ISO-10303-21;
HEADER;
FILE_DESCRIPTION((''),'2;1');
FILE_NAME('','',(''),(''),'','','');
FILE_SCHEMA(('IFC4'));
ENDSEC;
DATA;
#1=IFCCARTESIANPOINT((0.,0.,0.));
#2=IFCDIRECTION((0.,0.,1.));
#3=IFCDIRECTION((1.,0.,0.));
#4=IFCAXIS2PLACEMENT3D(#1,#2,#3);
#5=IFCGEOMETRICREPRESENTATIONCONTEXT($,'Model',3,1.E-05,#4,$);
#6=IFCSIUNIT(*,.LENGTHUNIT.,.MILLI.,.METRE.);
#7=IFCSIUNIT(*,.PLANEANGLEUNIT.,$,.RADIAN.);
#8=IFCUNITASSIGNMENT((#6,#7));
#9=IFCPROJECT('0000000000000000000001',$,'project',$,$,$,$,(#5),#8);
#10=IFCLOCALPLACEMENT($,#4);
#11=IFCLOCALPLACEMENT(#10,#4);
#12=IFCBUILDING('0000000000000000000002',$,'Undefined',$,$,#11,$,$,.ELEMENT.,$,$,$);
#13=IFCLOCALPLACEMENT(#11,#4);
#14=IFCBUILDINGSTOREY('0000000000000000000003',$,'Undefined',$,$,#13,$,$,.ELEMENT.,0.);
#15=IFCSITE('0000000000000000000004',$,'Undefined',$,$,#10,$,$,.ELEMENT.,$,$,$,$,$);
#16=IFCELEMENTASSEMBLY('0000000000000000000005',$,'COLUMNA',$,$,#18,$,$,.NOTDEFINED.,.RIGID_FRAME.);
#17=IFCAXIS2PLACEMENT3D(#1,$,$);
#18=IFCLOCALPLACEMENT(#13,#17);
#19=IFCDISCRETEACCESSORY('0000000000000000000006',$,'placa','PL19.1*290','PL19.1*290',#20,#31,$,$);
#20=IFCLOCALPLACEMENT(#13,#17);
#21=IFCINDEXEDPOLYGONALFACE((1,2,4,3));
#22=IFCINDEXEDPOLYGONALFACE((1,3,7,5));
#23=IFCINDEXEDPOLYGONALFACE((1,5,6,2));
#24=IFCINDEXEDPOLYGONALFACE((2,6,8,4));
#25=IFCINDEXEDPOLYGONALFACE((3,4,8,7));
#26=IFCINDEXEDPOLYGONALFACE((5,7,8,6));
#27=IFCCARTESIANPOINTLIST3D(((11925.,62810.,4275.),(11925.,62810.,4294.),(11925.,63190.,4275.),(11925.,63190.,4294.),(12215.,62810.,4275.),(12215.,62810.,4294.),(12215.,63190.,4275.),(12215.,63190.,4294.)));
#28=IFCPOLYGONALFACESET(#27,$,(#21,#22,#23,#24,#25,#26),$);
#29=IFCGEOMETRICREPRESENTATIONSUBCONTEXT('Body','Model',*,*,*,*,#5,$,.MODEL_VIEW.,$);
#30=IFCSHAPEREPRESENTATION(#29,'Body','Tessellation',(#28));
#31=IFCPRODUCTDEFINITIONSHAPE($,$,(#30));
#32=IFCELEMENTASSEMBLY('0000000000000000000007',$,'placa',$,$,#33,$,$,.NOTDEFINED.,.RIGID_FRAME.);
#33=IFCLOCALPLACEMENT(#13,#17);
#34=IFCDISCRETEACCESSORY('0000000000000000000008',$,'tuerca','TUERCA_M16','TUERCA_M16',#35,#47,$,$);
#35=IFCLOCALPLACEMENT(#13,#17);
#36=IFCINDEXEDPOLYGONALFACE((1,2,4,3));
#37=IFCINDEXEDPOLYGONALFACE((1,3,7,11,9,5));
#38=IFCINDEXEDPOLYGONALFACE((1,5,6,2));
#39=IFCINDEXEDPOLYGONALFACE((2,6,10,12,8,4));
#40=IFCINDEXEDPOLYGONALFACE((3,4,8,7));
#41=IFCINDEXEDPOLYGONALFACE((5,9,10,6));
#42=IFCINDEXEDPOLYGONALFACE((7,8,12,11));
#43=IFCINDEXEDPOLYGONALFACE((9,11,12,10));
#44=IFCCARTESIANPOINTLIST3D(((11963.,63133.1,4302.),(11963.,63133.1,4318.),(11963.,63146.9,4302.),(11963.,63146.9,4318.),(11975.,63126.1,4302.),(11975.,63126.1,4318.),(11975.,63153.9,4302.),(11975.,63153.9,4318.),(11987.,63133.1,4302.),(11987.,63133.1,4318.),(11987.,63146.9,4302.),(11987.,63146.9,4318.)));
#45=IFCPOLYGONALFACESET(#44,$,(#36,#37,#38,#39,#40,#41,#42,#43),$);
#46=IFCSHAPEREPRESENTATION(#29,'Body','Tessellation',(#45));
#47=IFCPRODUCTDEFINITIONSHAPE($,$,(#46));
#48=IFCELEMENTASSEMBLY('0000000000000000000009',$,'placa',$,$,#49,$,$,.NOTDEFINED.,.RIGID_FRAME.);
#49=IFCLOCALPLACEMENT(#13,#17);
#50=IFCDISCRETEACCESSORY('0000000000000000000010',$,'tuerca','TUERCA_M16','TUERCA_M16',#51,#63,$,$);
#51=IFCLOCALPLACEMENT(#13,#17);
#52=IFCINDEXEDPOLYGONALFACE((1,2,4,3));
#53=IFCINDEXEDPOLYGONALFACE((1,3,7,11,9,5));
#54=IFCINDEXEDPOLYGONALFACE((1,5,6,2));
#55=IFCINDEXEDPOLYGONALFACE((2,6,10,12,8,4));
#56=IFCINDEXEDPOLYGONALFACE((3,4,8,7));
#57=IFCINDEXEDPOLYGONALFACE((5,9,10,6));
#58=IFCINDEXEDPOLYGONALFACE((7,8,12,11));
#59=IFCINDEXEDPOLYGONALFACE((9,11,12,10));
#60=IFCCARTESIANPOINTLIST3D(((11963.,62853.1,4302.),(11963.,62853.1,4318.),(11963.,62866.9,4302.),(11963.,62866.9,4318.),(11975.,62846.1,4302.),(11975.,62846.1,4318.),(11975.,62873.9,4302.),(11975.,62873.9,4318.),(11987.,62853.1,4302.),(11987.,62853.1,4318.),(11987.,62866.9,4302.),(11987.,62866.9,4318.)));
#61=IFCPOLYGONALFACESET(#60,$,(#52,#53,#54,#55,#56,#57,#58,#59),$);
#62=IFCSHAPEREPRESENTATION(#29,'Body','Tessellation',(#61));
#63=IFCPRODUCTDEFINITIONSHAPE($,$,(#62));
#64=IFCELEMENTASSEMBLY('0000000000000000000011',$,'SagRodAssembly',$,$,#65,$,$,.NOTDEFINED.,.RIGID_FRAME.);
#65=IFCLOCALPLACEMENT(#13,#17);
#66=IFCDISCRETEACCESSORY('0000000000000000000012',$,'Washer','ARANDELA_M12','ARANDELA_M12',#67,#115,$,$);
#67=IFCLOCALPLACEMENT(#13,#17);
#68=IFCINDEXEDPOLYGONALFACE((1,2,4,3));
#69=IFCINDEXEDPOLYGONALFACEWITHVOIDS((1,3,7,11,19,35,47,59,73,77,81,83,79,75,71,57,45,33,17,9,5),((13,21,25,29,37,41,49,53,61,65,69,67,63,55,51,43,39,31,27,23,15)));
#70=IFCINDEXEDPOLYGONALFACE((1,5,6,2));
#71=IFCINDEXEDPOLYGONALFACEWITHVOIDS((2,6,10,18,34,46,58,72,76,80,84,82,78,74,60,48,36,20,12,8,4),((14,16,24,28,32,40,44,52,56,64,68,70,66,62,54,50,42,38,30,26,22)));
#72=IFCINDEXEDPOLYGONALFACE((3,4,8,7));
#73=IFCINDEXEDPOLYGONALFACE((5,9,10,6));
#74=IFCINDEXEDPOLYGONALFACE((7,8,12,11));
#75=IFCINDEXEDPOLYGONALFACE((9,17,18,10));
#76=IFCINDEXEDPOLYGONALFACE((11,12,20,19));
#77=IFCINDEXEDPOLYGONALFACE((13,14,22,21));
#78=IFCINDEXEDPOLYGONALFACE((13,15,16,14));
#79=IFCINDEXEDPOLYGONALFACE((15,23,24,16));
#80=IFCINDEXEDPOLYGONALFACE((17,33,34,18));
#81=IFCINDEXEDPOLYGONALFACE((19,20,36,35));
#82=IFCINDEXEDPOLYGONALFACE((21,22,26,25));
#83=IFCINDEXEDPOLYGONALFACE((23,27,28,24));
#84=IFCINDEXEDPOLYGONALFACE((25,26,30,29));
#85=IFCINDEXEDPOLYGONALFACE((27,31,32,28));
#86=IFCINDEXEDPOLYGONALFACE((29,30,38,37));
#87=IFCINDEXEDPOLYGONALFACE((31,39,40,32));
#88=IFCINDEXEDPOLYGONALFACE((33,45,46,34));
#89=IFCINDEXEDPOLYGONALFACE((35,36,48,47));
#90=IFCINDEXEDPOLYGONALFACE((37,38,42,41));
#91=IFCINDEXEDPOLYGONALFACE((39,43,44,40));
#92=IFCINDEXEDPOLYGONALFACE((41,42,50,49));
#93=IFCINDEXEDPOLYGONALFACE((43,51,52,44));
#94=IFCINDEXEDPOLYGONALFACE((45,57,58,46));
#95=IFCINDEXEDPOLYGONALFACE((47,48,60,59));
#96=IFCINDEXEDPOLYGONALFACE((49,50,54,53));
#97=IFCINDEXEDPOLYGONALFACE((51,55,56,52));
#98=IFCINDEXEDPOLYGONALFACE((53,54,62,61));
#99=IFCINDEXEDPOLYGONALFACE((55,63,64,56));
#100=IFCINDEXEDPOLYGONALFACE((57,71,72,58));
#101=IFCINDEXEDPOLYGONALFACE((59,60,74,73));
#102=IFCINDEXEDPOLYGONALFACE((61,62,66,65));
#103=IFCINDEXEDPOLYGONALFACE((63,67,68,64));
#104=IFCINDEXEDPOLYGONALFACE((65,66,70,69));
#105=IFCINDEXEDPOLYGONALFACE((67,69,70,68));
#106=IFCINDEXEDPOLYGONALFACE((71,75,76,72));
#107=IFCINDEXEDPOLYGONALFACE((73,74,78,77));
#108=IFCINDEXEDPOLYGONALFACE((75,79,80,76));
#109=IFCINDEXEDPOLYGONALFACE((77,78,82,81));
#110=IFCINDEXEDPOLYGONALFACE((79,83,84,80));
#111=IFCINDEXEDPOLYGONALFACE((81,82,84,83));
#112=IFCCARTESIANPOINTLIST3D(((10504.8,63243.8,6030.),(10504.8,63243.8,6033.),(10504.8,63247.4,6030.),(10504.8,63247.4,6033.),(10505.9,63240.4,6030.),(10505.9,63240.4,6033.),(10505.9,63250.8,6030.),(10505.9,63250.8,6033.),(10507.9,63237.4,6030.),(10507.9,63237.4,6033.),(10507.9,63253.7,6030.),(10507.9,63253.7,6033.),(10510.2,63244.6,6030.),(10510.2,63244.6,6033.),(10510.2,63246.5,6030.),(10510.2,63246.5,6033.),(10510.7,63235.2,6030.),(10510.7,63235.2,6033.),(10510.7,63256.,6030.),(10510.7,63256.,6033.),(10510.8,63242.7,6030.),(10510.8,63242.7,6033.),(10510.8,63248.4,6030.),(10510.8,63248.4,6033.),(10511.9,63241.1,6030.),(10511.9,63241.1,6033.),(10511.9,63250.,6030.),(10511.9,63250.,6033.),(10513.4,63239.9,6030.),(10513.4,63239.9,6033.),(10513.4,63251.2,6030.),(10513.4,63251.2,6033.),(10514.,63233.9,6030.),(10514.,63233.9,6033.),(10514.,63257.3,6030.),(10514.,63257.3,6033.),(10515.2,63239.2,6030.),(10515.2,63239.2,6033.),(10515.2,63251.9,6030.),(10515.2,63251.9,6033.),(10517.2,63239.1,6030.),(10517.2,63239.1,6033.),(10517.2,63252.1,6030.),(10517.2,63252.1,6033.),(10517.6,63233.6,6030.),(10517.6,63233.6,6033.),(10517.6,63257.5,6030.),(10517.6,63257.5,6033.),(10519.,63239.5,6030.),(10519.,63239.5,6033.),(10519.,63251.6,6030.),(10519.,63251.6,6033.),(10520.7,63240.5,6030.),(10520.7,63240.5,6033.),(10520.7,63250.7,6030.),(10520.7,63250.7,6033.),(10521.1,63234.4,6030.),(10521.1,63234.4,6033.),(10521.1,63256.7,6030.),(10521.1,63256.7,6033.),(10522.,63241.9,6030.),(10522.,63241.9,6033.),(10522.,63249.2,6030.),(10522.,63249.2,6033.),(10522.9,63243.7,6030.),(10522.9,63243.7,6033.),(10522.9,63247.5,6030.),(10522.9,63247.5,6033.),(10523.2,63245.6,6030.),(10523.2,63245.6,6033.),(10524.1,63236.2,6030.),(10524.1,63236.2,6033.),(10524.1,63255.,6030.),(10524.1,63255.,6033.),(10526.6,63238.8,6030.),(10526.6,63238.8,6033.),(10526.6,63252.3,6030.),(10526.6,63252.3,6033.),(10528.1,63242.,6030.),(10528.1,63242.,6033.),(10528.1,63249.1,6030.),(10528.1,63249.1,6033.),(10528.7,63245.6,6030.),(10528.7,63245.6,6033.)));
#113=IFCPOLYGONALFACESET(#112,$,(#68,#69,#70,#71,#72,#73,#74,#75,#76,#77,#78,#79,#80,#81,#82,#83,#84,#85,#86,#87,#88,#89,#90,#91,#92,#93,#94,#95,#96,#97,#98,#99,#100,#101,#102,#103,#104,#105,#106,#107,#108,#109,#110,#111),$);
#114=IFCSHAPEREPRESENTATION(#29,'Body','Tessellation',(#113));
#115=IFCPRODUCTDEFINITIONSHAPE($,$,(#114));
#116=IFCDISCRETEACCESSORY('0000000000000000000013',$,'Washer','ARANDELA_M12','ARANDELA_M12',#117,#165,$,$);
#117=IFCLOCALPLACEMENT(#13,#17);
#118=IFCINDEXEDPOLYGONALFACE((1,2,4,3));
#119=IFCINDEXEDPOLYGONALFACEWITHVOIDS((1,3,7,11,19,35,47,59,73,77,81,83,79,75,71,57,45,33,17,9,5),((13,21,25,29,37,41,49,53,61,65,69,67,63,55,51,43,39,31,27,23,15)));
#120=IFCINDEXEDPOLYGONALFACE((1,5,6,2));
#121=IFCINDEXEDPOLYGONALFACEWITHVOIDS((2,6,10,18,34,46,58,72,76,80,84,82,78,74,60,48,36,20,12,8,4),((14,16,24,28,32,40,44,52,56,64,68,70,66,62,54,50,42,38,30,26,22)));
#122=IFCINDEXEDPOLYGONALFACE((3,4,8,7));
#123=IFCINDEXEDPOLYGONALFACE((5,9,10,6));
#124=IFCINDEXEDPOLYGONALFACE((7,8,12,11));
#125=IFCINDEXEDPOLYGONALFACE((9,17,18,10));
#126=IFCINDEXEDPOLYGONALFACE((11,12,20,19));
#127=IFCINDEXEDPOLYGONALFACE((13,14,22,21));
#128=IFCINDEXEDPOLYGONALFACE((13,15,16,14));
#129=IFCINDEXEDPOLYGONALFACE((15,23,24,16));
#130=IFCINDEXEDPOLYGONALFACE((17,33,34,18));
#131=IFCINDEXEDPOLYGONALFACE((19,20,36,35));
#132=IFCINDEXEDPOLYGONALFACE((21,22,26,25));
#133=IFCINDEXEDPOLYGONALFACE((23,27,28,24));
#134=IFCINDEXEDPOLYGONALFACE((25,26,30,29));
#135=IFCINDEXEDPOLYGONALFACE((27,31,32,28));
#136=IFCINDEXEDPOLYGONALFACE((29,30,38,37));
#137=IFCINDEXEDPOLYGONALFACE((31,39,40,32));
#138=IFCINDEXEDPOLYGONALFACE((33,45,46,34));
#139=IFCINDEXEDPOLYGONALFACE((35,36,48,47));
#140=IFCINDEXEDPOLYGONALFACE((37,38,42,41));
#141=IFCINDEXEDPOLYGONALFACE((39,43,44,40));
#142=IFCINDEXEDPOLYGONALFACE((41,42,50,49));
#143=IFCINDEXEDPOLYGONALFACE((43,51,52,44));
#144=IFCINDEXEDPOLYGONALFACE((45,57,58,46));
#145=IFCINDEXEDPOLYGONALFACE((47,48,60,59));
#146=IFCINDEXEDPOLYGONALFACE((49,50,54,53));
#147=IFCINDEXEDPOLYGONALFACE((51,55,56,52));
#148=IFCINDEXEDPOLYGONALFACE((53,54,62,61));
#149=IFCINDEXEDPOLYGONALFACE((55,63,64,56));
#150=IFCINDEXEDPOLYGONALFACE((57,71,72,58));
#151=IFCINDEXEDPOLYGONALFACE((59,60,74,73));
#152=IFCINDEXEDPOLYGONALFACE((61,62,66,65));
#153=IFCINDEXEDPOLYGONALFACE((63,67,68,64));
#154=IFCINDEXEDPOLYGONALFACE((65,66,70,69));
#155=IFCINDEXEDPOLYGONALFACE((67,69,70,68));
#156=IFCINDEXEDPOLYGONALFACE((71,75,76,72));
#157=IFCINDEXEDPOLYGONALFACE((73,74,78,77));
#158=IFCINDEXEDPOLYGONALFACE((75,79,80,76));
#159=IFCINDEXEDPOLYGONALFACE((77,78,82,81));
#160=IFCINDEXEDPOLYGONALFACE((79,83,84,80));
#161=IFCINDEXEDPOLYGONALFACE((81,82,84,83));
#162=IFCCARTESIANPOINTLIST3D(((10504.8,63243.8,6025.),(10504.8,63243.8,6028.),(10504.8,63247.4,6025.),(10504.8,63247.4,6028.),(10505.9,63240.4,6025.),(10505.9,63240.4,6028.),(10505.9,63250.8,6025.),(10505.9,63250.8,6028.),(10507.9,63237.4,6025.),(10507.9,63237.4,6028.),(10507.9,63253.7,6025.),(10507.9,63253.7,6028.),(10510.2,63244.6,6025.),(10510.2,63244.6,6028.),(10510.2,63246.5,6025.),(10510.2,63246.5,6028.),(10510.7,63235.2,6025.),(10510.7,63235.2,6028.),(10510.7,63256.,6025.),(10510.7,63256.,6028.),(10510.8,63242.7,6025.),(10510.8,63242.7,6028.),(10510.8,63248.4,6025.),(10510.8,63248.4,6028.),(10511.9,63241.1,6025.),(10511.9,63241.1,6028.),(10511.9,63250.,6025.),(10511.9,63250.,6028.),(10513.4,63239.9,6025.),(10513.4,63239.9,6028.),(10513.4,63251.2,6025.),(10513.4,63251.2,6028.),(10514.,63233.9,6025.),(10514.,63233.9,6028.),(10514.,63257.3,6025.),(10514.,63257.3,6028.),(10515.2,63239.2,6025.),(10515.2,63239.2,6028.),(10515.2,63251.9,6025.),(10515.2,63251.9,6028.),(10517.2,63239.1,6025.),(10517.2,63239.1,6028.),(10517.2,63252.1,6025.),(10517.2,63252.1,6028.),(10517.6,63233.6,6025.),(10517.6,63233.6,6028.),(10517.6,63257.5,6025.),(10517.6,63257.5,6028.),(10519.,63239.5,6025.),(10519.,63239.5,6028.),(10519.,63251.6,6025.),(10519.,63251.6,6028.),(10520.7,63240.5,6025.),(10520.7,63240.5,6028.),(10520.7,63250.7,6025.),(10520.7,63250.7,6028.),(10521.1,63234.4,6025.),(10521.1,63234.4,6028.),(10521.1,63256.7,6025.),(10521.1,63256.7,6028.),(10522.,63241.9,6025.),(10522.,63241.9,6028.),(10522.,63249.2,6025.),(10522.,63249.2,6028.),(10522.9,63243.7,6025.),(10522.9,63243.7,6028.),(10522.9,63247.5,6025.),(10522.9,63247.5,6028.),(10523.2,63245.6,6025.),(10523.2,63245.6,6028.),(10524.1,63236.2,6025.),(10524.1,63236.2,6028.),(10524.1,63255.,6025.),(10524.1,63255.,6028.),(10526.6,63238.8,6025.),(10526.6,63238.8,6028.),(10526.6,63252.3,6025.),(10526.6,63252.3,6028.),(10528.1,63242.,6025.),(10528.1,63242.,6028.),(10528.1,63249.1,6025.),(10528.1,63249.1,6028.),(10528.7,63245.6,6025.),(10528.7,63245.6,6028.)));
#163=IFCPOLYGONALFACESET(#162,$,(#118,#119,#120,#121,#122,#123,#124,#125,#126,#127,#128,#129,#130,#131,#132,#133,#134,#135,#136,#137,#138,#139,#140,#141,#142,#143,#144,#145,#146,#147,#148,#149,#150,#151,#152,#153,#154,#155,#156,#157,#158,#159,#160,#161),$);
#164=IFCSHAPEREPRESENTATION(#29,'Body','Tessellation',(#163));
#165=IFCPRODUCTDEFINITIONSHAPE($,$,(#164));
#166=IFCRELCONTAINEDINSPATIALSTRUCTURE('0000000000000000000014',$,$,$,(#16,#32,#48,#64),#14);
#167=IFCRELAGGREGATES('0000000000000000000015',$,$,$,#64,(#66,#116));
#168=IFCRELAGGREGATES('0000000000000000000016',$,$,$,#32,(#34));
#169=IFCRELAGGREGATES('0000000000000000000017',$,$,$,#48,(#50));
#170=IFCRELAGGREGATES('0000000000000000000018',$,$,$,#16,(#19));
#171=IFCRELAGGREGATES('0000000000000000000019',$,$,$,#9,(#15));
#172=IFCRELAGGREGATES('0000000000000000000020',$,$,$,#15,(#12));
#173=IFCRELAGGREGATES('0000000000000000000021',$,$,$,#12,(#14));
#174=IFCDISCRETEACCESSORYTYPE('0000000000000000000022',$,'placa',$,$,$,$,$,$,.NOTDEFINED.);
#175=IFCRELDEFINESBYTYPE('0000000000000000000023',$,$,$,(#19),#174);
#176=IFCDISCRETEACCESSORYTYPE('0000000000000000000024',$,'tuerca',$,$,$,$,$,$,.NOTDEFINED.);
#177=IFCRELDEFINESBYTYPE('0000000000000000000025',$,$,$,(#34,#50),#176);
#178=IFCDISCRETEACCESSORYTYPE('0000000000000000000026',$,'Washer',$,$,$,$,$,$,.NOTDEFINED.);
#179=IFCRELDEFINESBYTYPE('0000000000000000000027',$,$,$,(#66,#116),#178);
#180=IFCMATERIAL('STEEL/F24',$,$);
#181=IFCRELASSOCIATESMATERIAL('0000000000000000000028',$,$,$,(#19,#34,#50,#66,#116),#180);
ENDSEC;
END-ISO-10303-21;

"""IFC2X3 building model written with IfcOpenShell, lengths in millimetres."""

from ifc_helpers import new_model, si_unit, frame, origin_with_axes, origin_2d_with_axis, place, context, subcontext, project, spatial, polyline, hollow_circle, outline, extrude, material, type_object, element, aggregate, save


model = new_model("IFC2X3")

# Units and contexts
model_context = context("Model", 3, precision=1e-05, world=origin_with_axes())
body_context = subcontext(model_context, "Body", "Model", "MODEL_VIEW")
ifc_project = project(units=[si_unit("LENGTHUNIT", "METRE", prefix="MILLI"), si_unit("PLANEANGLEUNIT", "RADIAN")], contexts=[model_context])

# Site, building, storey
site_placement = place(None, origin_with_axes())
site = spatial("IfcSite", under=ifc_project, at=site_placement, Name="Undefined", CompositionType="ELEMENT")
building_placement = place(site_placement, origin_with_axes())
building = spatial("IfcBuilding", under=site, at=building_placement, Name="Undefined", CompositionType="ELEMENT")
storey_placement = place(building_placement, origin_with_axes())
storey = spatial("IfcBuildingStorey", under=building, at=storey_placement, Name="Undefined", CompositionType="ELEMENT", Elevation=0.0)

# Element assembly
assembly_1_placement = place(storey_placement, origin_with_axes())
assembly_1 = element("IfcElementAssembly", 1, at=assembly_1_placement, inside=storey, Name="COLUMNA", AssemblyPlace="NOTDEFINED", PredefinedType="RIGID_FRAME")
ifc_material_1 = material(Name="STEEL/F24")

# Discrete accessory
discrete_accessory_type_1 = type_object("IfcDiscreteAccessoryType", Name="placa")
discrete_accessory_1_placement = place(assembly_1_placement, frame((12070.0, 63190.0, 4284.5), z_axis=(0.0, 0.0, 1.0), x_axis=(0.0, -1.0, 0.0)))
discrete_accessory_1 = element("IfcDiscreteAccessory", 2, at=discrete_accessory_1_placement, type_object=discrete_accessory_type_1, material=ifc_material_1, Name="placa", Description="PL19.1*290", ObjectType="PL19.1*290", context=body_context, shape_type="SweptSolid", body=[
    extrude(outline(polyline([(380.0, -145.0), (0.0, -145.0), (0.0, 145.0), (380.0, 145.0), (380.0, -145.0)])), frame((0.0, 0.0, -9.6), z_axis=(0.0, 0.0, 1.0), x_axis=(1.0, 0.0, 0.0)), (0.0, 0.0, 1.0), 19.1),
])

# Element assemblies, discrete accessories
assembly_2_placement = place(storey_placement, origin_with_axes())
assembly_2 = element("IfcElementAssembly", 3, at=assembly_2_placement, inside=storey, Name="placa", AssemblyPlace="NOTDEFINED", PredefinedType="RIGID_FRAME")
discrete_accessory_type_2 = type_object("IfcDiscreteAccessoryType", Name="tuerca")
discrete_accessory_2_placement = place(assembly_2_placement, frame((11975.0, 63140.0, 4318.1), z_axis=(0.0, 0.0, -1.0), x_axis=(0.0, -1.0, 0.0)))
discrete_accessory_2 = element("IfcDiscreteAccessory", 4, at=discrete_accessory_2_placement, type_object=discrete_accessory_type_2, material=ifc_material_1, Name="tuerca", Description="TUERCA_M16", ObjectType="TUERCA_M16", context=body_context, shape_type="SweptSolid", body=[
    extrude(outline(polyline([(-12.0, 6.9), (0.0, 13.9), (12.0, 6.9), (12.0, -6.9), (0.0, -13.9), (-12.0, -6.9), (-12.0, 6.9)])), frame((0.0, 0.0, 16.0), z_axis=(0.0, 0.0, -1.0), x_axis=(0.0, 1.0, 0.0)), (0.0, 0.0, 1.0), 16.0),
])
assembly_3_placement = place(storey_placement, origin_with_axes())
assembly_3 = element("IfcElementAssembly", 5, at=assembly_3_placement, inside=storey, Name="placa", AssemblyPlace="NOTDEFINED", PredefinedType="RIGID_FRAME")
discrete_accessory_3_placement = place(assembly_3_placement, frame((11975.0, 62860.0, 4318.1), z_axis=(0.0, 0.0, -1.0), x_axis=(0.0, -1.0, 0.0)))
discrete_accessory_3 = element("IfcDiscreteAccessory", 6, at=discrete_accessory_3_placement, type_object=discrete_accessory_type_2, material=ifc_material_1, Name="tuerca", Description="TUERCA_M16", ObjectType="TUERCA_M16", context=body_context, shape_type="SweptSolid", body=[
    extrude(outline(polyline([(-12.0, 6.9), (0.0, 13.9), (12.0, 6.9), (12.0, -6.9), (0.0, -13.9), (-12.0, -6.9), (-12.0, 6.9)])), frame((0.0, 0.0, 16.0), z_axis=(0.0, 0.0, -1.0), x_axis=(0.0, 1.0, 0.0)), (0.0, 0.0, 1.0), 16.0),
])

# Element assembly, discrete accessories
assembly_4_placement = place(storey_placement, origin_with_axes())
assembly_4 = element("IfcElementAssembly", 7, at=assembly_4_placement, inside=storey, Name="SagRodAssembly", AssemblyPlace="NOTDEFINED", PredefinedType="RIGID_FRAME")
discrete_accessory_type_3 = type_object("IfcDiscreteAccessoryType", Name="Washer")
discrete_accessory_4_placement = place(assembly_4_placement, frame((10516.7, 63245.6, 6030.0), z_axis=(0.0, 0.0, 1.0), x_axis=(0.0, -1.0, 0.0)))
discrete_accessory_4 = element("IfcDiscreteAccessory", 8, at=discrete_accessory_4_placement, type_object=discrete_accessory_type_3, material=ifc_material_1, Name="Washer", Description="ARANDELA_M12", ObjectType="ARANDELA_M12", context=body_context, shape_type="SweptSolid", body=[
    extrude(hollow_circle(Radius=12.0, WallThickness=5.5, at=origin_2d_with_axis()), frame((0.0, 0.0, 3.0), z_axis=(0.0, 0.0, -1.0), x_axis=(0.0, 1.0, 0.0)), (0.0, 0.0, 1.0), 3.0),
])
discrete_accessory_5_placement = place(assembly_4_placement, frame((10516.7, 63245.6, 6025.0), z_axis=(0.0, 0.0, 1.0), x_axis=(0.0, -1.0, 0.0)))
discrete_accessory_5 = element("IfcDiscreteAccessory", 9, at=discrete_accessory_5_placement, type_object=discrete_accessory_type_3, material=ifc_material_1, Name="Washer", Description="ARANDELA_M12", ObjectType="ARANDELA_M12", context=body_context, shape_type="SweptSolid", body=[
    extrude(hollow_circle(Radius=12.0, WallThickness=5.5, at=origin_2d_with_axis()), frame((0.0, 0.0, 3.0), z_axis=(0.0, 0.0, -1.0), x_axis=(0.0, 1.0, 0.0)), (0.0, 0.0, 1.0), 3.0),
])
aggregate(assembly_4, [discrete_accessory_4, discrete_accessory_5])

aggregate(assembly_2, [discrete_accessory_2])
aggregate(assembly_3, [discrete_accessory_3])

aggregate(assembly_1, [discrete_accessory_1])

save(model, "model.ifc")
